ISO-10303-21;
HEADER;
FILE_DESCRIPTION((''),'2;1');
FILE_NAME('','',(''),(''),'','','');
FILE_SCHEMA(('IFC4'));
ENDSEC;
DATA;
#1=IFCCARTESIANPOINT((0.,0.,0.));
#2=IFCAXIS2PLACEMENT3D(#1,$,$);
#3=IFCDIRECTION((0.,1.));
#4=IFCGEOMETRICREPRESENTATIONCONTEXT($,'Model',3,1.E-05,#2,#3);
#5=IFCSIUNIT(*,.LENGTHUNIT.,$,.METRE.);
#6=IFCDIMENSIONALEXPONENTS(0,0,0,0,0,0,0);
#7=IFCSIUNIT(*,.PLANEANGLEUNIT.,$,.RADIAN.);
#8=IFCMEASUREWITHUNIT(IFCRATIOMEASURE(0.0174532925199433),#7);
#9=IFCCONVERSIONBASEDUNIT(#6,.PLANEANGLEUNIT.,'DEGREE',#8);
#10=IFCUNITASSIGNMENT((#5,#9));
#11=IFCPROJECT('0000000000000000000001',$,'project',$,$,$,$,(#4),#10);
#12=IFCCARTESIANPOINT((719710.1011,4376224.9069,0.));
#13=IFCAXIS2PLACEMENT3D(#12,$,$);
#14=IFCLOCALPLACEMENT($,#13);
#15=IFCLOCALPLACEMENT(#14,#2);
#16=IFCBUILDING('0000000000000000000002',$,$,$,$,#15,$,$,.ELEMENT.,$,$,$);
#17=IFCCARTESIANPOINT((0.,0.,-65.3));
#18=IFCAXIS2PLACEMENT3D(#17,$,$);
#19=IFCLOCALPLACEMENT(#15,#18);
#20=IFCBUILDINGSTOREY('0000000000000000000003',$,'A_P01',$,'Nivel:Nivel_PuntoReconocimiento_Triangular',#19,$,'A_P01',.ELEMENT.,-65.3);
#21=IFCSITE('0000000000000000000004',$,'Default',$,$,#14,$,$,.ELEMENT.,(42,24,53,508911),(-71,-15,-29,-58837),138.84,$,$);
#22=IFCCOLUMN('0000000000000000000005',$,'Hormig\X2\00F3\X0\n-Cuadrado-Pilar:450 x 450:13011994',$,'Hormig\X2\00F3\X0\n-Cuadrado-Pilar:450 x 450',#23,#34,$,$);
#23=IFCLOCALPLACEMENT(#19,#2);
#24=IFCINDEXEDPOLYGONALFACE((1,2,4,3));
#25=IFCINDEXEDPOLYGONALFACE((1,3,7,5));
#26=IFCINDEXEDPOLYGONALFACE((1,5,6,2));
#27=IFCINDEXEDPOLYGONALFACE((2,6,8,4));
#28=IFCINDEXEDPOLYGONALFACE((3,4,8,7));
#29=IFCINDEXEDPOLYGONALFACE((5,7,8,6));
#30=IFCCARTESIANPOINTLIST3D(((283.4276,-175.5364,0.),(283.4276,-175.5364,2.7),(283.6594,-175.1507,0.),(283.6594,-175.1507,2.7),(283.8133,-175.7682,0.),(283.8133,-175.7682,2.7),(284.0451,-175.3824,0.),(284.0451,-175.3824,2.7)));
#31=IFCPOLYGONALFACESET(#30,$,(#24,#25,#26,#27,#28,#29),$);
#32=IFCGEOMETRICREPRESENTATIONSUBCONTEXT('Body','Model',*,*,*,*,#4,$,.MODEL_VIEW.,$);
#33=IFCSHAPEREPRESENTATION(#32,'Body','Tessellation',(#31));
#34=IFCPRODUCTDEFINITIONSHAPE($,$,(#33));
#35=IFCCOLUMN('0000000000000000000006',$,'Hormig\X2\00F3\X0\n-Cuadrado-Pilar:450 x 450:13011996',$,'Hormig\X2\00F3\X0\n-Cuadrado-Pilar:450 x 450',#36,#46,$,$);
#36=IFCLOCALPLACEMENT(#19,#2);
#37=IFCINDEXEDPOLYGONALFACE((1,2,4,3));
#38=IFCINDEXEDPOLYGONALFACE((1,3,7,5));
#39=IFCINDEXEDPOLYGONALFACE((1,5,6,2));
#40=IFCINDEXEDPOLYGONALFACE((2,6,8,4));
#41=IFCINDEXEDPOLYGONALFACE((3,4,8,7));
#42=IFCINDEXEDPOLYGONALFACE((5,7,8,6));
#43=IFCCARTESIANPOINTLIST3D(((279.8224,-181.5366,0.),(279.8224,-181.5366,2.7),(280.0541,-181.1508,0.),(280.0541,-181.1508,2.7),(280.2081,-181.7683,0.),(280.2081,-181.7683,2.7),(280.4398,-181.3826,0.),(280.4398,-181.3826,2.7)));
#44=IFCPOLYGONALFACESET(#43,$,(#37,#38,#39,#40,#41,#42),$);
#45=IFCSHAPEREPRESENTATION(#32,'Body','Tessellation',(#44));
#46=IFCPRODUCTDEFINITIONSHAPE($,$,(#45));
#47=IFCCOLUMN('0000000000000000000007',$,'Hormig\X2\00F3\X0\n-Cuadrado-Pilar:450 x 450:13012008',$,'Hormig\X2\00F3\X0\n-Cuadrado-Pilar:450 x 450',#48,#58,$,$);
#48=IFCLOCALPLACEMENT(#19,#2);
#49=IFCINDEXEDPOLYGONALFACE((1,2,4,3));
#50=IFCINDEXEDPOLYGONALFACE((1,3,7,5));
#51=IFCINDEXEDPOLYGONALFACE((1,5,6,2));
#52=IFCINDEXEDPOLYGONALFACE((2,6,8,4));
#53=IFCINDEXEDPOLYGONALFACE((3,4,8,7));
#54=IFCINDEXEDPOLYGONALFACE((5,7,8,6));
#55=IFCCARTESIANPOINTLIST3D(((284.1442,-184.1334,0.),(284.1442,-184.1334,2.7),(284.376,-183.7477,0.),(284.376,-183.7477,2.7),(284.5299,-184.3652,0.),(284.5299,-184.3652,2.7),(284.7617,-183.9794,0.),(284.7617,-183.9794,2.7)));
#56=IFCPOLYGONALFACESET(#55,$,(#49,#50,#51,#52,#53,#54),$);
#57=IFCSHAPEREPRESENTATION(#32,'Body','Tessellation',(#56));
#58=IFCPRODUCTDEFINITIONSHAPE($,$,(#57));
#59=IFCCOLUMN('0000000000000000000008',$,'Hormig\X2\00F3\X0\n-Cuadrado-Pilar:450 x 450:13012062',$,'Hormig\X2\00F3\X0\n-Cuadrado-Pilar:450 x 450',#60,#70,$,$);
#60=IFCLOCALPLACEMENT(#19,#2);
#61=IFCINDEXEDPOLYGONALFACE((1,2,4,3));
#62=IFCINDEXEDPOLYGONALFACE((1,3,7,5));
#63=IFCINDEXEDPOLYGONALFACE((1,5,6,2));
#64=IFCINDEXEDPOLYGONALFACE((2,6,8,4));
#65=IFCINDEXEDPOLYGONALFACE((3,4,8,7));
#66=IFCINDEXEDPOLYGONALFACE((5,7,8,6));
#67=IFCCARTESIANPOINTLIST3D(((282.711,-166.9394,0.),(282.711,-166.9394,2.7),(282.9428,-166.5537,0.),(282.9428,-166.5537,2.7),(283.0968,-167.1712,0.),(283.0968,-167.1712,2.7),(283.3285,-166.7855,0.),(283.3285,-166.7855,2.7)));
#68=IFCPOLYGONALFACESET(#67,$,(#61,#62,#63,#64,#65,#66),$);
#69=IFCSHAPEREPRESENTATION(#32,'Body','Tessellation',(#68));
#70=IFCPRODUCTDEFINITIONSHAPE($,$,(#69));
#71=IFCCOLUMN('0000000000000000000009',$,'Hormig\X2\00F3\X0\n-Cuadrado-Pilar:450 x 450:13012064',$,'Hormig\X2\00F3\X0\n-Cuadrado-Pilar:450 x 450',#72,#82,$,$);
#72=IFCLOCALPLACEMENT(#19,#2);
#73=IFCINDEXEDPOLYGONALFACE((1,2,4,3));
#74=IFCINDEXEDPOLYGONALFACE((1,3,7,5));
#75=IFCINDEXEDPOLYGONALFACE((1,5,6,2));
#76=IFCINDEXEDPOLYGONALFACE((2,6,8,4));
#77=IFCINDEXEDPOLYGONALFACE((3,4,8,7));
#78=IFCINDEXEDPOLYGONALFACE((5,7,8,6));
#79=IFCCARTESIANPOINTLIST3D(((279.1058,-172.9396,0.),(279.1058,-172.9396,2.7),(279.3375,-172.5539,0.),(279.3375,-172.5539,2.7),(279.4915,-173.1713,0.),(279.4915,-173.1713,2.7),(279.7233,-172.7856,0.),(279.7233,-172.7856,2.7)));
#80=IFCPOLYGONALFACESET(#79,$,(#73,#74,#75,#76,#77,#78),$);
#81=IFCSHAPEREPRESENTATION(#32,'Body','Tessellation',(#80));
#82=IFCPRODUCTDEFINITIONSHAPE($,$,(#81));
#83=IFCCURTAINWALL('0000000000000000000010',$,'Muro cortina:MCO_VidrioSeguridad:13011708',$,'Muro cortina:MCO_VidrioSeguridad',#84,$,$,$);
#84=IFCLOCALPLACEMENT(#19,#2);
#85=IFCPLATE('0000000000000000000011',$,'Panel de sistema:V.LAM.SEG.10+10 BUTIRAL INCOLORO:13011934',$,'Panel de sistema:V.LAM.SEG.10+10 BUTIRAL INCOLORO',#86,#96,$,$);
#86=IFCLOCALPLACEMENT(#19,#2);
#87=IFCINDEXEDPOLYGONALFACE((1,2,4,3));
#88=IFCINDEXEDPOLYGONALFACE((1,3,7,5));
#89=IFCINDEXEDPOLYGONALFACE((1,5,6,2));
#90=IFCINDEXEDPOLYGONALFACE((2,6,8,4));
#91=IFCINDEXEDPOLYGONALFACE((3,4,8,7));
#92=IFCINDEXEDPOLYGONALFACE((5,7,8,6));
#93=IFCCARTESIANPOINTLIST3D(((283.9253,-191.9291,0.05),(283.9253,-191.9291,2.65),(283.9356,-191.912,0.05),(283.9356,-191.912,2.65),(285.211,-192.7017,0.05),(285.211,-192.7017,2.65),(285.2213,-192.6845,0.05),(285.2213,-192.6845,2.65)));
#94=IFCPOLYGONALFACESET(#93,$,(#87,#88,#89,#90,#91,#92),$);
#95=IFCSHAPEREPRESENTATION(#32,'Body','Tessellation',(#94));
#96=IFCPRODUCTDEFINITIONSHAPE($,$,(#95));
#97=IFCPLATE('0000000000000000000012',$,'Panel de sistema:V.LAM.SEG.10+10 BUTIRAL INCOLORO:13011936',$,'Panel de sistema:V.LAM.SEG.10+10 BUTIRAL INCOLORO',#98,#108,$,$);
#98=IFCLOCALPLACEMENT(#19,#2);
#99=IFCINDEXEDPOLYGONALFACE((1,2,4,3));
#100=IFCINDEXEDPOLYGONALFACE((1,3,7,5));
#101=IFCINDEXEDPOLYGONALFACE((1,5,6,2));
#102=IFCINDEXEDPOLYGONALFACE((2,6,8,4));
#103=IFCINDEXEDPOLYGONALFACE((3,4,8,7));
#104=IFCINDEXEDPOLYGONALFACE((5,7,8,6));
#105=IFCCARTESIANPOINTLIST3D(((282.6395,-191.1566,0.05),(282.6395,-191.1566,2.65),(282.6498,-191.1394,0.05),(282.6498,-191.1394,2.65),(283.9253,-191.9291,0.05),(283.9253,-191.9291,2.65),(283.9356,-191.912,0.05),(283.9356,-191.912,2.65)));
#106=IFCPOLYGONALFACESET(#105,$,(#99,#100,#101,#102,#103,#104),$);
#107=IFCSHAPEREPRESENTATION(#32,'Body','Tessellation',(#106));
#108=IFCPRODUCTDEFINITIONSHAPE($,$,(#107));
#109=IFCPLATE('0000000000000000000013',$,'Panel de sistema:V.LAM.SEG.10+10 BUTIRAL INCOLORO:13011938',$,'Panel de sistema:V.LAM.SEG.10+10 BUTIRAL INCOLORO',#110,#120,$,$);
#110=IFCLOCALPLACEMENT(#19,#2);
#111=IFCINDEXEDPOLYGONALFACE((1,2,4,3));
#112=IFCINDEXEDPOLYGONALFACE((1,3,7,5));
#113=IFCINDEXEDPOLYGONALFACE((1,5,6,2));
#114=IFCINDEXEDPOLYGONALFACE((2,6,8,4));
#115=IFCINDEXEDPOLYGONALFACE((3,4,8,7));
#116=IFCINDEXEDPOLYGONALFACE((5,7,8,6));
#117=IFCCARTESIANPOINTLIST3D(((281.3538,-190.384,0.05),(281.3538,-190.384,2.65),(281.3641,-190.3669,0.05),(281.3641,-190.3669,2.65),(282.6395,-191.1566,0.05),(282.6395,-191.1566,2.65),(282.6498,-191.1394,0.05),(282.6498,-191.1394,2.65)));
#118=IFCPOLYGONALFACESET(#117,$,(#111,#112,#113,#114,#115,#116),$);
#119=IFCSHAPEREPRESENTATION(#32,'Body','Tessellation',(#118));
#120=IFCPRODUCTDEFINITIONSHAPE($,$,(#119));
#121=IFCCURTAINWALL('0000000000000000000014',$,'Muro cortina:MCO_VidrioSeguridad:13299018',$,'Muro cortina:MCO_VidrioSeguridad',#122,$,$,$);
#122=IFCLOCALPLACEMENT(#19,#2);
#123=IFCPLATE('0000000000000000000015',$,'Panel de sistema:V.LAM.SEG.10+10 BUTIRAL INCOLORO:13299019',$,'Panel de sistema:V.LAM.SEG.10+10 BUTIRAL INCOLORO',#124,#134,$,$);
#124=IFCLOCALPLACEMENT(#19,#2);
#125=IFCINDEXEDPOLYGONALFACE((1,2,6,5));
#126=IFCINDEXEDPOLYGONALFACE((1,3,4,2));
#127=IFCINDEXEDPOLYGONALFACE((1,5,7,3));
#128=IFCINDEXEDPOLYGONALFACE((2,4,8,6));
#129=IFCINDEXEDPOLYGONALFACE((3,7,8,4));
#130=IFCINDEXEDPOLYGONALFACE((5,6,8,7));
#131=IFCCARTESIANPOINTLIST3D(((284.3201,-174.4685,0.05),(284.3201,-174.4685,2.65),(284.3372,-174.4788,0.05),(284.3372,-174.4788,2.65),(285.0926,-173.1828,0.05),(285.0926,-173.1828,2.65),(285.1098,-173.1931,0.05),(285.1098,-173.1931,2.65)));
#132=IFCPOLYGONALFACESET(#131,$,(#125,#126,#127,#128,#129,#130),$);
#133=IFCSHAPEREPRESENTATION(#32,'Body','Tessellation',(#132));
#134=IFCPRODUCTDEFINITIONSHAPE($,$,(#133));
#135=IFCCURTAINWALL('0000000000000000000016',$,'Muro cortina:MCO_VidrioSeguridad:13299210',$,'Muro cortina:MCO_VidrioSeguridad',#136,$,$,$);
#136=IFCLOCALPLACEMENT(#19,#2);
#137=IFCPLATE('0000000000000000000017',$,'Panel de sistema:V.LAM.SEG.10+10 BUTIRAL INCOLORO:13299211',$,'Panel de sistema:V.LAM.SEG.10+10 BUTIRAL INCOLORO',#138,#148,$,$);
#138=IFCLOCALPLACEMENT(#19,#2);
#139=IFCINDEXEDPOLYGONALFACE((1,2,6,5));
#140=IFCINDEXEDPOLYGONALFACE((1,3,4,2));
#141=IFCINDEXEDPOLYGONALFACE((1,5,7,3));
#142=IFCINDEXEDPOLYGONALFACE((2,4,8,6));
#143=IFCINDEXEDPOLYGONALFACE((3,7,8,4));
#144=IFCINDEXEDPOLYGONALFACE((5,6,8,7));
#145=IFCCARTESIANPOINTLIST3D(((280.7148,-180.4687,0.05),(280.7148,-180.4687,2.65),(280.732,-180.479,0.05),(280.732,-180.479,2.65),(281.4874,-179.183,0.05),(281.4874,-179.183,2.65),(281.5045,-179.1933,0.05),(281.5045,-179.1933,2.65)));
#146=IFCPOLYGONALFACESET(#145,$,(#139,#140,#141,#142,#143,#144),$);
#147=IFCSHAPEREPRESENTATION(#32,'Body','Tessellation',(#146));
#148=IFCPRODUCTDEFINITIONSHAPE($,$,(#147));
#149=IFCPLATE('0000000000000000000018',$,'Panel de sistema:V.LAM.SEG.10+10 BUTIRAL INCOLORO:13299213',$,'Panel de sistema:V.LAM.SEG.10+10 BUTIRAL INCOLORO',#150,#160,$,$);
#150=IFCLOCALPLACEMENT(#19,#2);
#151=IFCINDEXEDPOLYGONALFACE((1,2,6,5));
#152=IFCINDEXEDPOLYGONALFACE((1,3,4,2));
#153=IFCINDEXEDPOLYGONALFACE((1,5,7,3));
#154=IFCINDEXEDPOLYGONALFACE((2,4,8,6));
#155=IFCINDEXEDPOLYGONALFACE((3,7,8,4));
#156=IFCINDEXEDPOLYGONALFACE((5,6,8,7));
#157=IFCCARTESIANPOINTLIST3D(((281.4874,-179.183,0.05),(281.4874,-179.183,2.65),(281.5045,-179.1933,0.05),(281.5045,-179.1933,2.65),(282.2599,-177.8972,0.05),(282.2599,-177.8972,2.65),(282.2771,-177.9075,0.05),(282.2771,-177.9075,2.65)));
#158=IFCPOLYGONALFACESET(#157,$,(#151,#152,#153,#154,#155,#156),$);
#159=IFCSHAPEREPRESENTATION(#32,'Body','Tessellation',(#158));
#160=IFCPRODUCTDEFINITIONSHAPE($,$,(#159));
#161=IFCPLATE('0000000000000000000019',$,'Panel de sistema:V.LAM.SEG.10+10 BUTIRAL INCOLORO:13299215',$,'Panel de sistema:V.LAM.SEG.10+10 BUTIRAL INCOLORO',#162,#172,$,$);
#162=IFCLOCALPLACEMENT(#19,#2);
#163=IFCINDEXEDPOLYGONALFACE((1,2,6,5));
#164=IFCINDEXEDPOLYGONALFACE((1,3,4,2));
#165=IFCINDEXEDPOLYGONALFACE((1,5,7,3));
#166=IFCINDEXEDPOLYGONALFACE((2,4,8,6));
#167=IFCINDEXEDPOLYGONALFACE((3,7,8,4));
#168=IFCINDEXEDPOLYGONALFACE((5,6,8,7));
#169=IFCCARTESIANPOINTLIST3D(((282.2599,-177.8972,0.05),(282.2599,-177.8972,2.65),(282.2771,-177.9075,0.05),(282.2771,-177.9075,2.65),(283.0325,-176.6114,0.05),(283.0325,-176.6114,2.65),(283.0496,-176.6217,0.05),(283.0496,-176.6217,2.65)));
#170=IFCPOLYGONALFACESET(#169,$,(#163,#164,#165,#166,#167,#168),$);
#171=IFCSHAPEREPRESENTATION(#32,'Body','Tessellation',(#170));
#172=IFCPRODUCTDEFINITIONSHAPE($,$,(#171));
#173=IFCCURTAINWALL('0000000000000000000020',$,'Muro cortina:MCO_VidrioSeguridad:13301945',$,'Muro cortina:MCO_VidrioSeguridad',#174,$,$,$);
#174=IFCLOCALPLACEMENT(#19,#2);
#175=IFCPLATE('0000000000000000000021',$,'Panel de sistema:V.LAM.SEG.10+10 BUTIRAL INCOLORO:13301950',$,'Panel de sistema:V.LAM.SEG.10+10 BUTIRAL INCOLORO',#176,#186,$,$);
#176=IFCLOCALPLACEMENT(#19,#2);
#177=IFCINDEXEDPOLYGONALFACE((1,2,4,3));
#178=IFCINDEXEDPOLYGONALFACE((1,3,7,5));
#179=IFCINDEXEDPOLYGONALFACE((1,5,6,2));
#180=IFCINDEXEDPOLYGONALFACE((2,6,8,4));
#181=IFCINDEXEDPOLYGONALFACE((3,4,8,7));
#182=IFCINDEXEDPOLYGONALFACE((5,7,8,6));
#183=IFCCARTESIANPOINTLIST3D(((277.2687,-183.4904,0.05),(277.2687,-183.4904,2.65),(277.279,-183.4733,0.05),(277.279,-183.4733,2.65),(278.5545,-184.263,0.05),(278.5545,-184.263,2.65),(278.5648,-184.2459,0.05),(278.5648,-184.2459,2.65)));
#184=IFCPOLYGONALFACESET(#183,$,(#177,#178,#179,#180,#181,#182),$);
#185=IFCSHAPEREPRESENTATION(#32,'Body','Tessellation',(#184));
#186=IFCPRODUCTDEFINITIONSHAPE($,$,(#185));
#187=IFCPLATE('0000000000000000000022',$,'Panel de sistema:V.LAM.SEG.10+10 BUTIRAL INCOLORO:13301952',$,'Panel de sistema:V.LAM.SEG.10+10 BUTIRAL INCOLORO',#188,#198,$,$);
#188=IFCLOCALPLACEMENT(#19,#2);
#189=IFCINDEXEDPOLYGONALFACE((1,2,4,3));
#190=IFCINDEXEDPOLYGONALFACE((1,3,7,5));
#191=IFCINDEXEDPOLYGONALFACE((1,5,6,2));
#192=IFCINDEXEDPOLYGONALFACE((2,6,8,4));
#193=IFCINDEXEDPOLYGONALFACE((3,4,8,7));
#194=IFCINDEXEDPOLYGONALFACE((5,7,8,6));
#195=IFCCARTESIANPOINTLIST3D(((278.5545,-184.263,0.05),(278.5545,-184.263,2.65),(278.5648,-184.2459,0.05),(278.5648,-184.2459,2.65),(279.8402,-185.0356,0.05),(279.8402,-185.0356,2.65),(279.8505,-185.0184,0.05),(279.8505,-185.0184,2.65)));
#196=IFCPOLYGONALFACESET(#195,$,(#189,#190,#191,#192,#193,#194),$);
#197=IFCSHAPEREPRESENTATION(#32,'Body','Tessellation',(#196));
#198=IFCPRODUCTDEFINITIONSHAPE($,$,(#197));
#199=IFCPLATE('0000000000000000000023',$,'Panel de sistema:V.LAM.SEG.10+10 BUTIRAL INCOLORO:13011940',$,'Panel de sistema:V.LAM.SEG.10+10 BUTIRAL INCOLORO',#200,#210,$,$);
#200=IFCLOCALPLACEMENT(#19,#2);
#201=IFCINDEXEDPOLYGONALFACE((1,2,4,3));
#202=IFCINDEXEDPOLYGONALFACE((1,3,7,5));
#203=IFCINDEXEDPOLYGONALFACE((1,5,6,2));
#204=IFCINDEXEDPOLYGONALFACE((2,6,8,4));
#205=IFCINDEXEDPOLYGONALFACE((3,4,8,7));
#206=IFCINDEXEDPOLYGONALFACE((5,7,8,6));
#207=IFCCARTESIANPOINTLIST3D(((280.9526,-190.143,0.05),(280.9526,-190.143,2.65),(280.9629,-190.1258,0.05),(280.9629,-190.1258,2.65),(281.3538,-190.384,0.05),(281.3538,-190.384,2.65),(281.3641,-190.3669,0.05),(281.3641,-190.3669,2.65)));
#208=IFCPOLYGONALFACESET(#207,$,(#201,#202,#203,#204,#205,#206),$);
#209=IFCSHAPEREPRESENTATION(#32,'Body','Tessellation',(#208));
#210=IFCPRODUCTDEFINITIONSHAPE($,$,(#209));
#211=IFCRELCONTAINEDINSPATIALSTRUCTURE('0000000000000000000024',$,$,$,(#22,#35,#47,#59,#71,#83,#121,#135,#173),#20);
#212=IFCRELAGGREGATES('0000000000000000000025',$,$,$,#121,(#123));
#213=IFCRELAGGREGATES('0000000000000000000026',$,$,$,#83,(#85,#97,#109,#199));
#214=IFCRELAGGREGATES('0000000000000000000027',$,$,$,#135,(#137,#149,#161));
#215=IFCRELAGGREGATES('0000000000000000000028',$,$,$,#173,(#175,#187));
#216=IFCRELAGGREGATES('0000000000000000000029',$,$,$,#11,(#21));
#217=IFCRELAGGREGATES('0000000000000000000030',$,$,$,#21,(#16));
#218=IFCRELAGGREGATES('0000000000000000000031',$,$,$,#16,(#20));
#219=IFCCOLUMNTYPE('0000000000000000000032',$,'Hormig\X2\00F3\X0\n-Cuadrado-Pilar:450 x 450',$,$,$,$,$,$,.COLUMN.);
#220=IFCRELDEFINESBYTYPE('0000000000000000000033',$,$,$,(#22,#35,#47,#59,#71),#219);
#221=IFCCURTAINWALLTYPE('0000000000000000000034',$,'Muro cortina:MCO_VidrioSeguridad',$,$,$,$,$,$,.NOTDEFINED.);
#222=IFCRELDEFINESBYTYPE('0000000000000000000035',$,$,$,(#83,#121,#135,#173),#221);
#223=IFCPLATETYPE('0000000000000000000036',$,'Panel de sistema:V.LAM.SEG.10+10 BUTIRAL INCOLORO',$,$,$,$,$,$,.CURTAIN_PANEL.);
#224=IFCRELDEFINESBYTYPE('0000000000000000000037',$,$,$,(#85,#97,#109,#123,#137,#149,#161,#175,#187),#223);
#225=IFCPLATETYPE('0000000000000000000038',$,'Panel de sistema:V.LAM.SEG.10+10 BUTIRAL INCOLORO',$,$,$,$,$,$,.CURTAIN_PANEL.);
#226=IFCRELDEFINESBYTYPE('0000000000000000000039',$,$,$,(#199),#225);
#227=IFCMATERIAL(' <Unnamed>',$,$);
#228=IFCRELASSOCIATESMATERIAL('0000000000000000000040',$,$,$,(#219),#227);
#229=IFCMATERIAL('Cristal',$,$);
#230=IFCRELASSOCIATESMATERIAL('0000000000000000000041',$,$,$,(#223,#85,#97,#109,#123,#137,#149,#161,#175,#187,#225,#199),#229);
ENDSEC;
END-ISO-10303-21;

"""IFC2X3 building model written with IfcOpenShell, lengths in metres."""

from ifc_helpers import new_model, entity, si_unit, converted_unit, direction, frame, origin, origin_2d_with_axis, place, context, subcontext, project, spatial, rectangle, extrude, source, transform, mapped, material, type_object, type_shapes, element, aggregate, save


model = new_model("IFC2X3")

# Units and contexts
model_context = context("Model", 3, precision=1e-05, world=origin(), true_north=direction((0.0, 1.0)))
body_context = subcontext(model_context, "Body", "Model", "MODEL_VIEW")
ifc_project = project(units=[si_unit("LENGTHUNIT", "METRE"), converted_unit("PLANEANGLEUNIT", "DEGREE", entity("IfcRatioMeasure", 0.0174532925199433), si_unit("PLANEANGLEUNIT", "RADIAN"), dimensions=[0, 0, 0, 0, 0, 0, 0])], contexts=[model_context])

# Site, building, storey
site_placement = place(None, frame((719710.1011, 4376224.9069, 0.0)))
site = spatial("IfcSite", under=ifc_project, at=site_placement, Name="Default", CompositionType="ELEMENT", RefLatitude=(42, 24, 53, 508911), RefLongitude=(-71, -15, -29, -58837), RefElevation=138.84)
building_placement = place(site_placement, origin())
building = spatial("IfcBuilding", under=site, at=building_placement, CompositionType="ELEMENT")
storey_placement = place(building_placement, frame((0.0, 0.0, -65.3)))
storey = spatial("IfcBuildingStorey", under=building, at=storey_placement, Name="A_P01", ObjectType="Nivel:Nivel_PuntoReconocimiento_Triangular", LongName="A_P01", CompositionType="ELEMENT", Elevation=-65.3)

# Columns
ifc_material_1 = material(Name=" <Unnamed>")
column_type = type_object("IfcColumnType", Name="Hormigón-Cuadrado-Pilar:450 x 450", PredefinedType="COLUMN", material=ifc_material_1)
shared_shape_1 = source(origin(), body_context, "Body", "SweptSolid", [
    extrude(rectangle(XDim=0.45, YDim=0.45, at=origin_2d_with_axis()), frame((0.0, 0.0, -65.3), z_axis=(0.0, 0.0, 1.0), x_axis=(0.0, -1.0, 0.0)), (0.0, 0.0, 1.0), 2.7),
])
type_shapes(column_type, [shared_shape_1])
for number, where, z_axis, x_axis, name in (
    (1, (283.7364, -175.4594, 65.3), (0.0, 0.0, 1.0), (0.857167, -0.515038, 0.0), "Hormigón-Cuadrado-Pilar:450 x 450:13011994"),
    (2, (280.1311, -181.4596, 65.3), (0.0, 0.0, 1.0), (0.857167, -0.515038, 0.0), "Hormigón-Cuadrado-Pilar:450 x 450:13011996"),
    (3, (284.4529, -184.0564, 65.3), (0.0, 0.0, 1.0), (0.857167, -0.515038, 0.0), "Hormigón-Cuadrado-Pilar:450 x 450:13012008"),
    (4, (283.0198, -166.8624, 65.3), (0.0, 0.0, 1.0), (0.857167, -0.515038, 0.0), "Hormigón-Cuadrado-Pilar:450 x 450:13012062"),
    (5, (279.4145, -172.8626, 65.3), (0.0, 0.0, 1.0), (0.857167, -0.515038, 0.0), "Hormigón-Cuadrado-Pilar:450 x 450:13012064"),
):
    element("IfcColumn", number, at=place(storey_placement, frame(where, z_axis=z_axis, x_axis=x_axis)), inside=storey, type_object=column_type, Name=name, ObjectType="Hormigón-Cuadrado-Pilar:450 x 450", context=body_context, shape_type="MappedRepresentation", body=[
        mapped(shared_shape_1, transform((0.0, 0.0, 0.0), scale=1.0)),
    ])

# Curtain wall, plates
curtain_wall_type = type_object("IfcCurtainWallType", Name="Muro cortina:MCO_VidrioSeguridad", PredefinedType="NOTDEFINED")
curtain_wall_1_placement = place(storey_placement, frame((0.0, 0.0, 65.3)))
curtain_wall_1 = element("IfcCurtainWall", 6, at=curtain_wall_1_placement, inside=storey, type_object=curtain_wall_type, Name="Muro cortina:MCO_VidrioSeguridad:13011708", ObjectType="Muro cortina:MCO_VidrioSeguridad")
ifc_material_2 = material(Name="Cristal")
plate_type_1 = type_object("IfcPlateType", Name="Panel de sistema:V.LAM.SEG.10+10 BUTIRAL INCOLORO", PredefinedType="CURTAIN_PANEL", material=ifc_material_2)
shared_shape_2 = source(origin(), body_context, "Body", "SweptSolid", [
    extrude(rectangle(XDim=0.02, YDim=1.5, at=origin_2d_with_axis()), frame((0.0, 0.0, 0.0), z_axis=(0.0, 0.0, 1.0), x_axis=(0.0, 1.0, 0.0)), (0.0, 0.0, 1.0), 2.6),
])
type_shapes(plate_type_1, [shared_shape_2])
plate_1_placement = place(curtain_wall_1_placement, frame((284.5733, -192.3068, -65.25), z_axis=(0.0, 0.0, 1.0), x_axis=(-0.857167, 0.515038, 0.0)))
plate_1 = element("IfcPlate", 7, at=plate_1_placement, type_object=plate_type_1, material=ifc_material_2, Name="Panel de sistema:V.LAM.SEG.10+10 BUTIRAL INCOLORO:13011934", ObjectType="Panel de sistema:V.LAM.SEG.10+10 BUTIRAL INCOLORO", context=body_context, shape_type="MappedRepresentation", body=[
    mapped(shared_shape_2, transform((0.0, 0.0, 0.0), scale=1.0)),
])
plate_2_placement = place(curtain_wall_1_placement, frame((283.2875, -191.5343, -65.25), z_axis=(0.0, 0.0, 1.0), x_axis=(-0.857167, 0.515038, 0.0)))
plate_2 = element("IfcPlate", 8, at=plate_2_placement, type_object=plate_type_1, material=ifc_material_2, Name="Panel de sistema:V.LAM.SEG.10+10 BUTIRAL INCOLORO:13011936", ObjectType="Panel de sistema:V.LAM.SEG.10+10 BUTIRAL INCOLORO", context=body_context, shape_type="MappedRepresentation", body=[
    mapped(shared_shape_2, transform((0.0, 0.0, 0.0), scale=1.0)),
])
plate_3_placement = place(curtain_wall_1_placement, frame((282.0018, -190.7617, -65.25), z_axis=(0.0, 0.0, 1.0), x_axis=(-0.857167, 0.515038, 0.0)))
plate_3 = element("IfcPlate", 9, at=plate_3_placement, type_object=plate_type_1, material=ifc_material_2, Name="Panel de sistema:V.LAM.SEG.10+10 BUTIRAL INCOLORO:13011938", ObjectType="Panel de sistema:V.LAM.SEG.10+10 BUTIRAL INCOLORO", context=body_context, shape_type="MappedRepresentation", body=[
    mapped(shared_shape_2, transform((0.0, 0.0, 0.0), scale=1.0)),
])

# Curtain wall, plate
curtain_wall_2_placement = place(storey_placement, frame((0.0, 0.0, 65.3)))
curtain_wall_2 = element("IfcCurtainWall", 10, at=curtain_wall_2_placement, inside=storey, type_object=curtain_wall_type, Name="Muro cortina:MCO_VidrioSeguridad:13299018", ObjectType="Muro cortina:MCO_VidrioSeguridad")
plate_4_placement = place(curtain_wall_2_placement, frame((284.7149, -173.8308, -65.25), z_axis=(0.0, 0.0, 1.0), x_axis=(0.515038, 0.857167, 0.0)))
plate_4 = element("IfcPlate", 11, at=plate_4_placement, type_object=plate_type_1, material=ifc_material_2, Name="Panel de sistema:V.LAM.SEG.10+10 BUTIRAL INCOLORO:13299019", ObjectType="Panel de sistema:V.LAM.SEG.10+10 BUTIRAL INCOLORO", context=body_context, shape_type="MappedRepresentation", body=[
    mapped(shared_shape_2, transform((0.0, 0.0, 0.0), scale=1.0)),
])
aggregate(curtain_wall_2, [plate_4])

# Curtain walls, plates
curtain_wall_3_placement = place(storey_placement, frame((0.0, 0.0, 65.3)))
curtain_wall_3 = element("IfcCurtainWall", 12, at=curtain_wall_3_placement, inside=storey, type_object=curtain_wall_type, Name="Muro cortina:MCO_VidrioSeguridad:13299210", ObjectType="Muro cortina:MCO_VidrioSeguridad")
plate_5_placement = place(curtain_wall_3_placement, frame((281.1097, -179.831, -65.25), z_axis=(0.0, 0.0, 1.0), x_axis=(0.515038, 0.857167, 0.0)))
plate_5 = element("IfcPlate", 13, at=plate_5_placement, type_object=plate_type_1, material=ifc_material_2, Name="Panel de sistema:V.LAM.SEG.10+10 BUTIRAL INCOLORO:13299211", ObjectType="Panel de sistema:V.LAM.SEG.10+10 BUTIRAL INCOLORO", context=body_context, shape_type="MappedRepresentation", body=[
    mapped(shared_shape_2, transform((0.0, 0.0, 0.0), scale=1.0)),
])
plate_6_placement = place(curtain_wall_3_placement, frame((281.8822, -178.5452, -65.25), z_axis=(0.0, 0.0, 1.0), x_axis=(0.515038, 0.857167, 0.0)))
plate_6 = element("IfcPlate", 14, at=plate_6_placement, type_object=plate_type_1, material=ifc_material_2, Name="Panel de sistema:V.LAM.SEG.10+10 BUTIRAL INCOLORO:13299213", ObjectType="Panel de sistema:V.LAM.SEG.10+10 BUTIRAL INCOLORO", context=body_context, shape_type="MappedRepresentation", body=[
    mapped(shared_shape_2, transform((0.0, 0.0, 0.0), scale=1.0)),
])
plate_7_placement = place(curtain_wall_3_placement, frame((282.6548, -177.2595, -65.25), z_axis=(0.0, 0.0, 1.0), x_axis=(0.515038, 0.857167, 0.0)))
plate_7 = element("IfcPlate", 15, at=plate_7_placement, type_object=plate_type_1, material=ifc_material_2, Name="Panel de sistema:V.LAM.SEG.10+10 BUTIRAL INCOLORO:13299215", ObjectType="Panel de sistema:V.LAM.SEG.10+10 BUTIRAL INCOLORO", context=body_context, shape_type="MappedRepresentation", body=[
    mapped(shared_shape_2, transform((0.0, 0.0, 0.0), scale=1.0)),
])
curtain_wall_4_placement = place(storey_placement, frame((0.0, 0.0, 65.3)))
curtain_wall_4 = element("IfcCurtainWall", 16, at=curtain_wall_4_placement, inside=storey, type_object=curtain_wall_type, Name="Muro cortina:MCO_VidrioSeguridad:13301945", ObjectType="Muro cortina:MCO_VidrioSeguridad")
plate_8_placement = place(curtain_wall_4_placement, frame((277.9168, -183.8681, -65.25), z_axis=(0.0, 0.0, 1.0), x_axis=(0.857167, -0.515038, 0.0)))
plate_8 = element("IfcPlate", 17, at=plate_8_placement, type_object=plate_type_1, material=ifc_material_2, Name="Panel de sistema:V.LAM.SEG.10+10 BUTIRAL INCOLORO:13301950", ObjectType="Panel de sistema:V.LAM.SEG.10+10 BUTIRAL INCOLORO", context=body_context, shape_type="MappedRepresentation", body=[
    mapped(shared_shape_2, transform((0.0, 0.0, 0.0), scale=1.0)),
])
plate_9_placement = place(curtain_wall_4_placement, frame((279.2025, -184.6407, -65.25), z_axis=(0.0, 0.0, 1.0), x_axis=(0.857167, -0.515038, 0.0)))
plate_9 = element("IfcPlate", 18, at=plate_9_placement, type_object=plate_type_1, material=ifc_material_2, Name="Panel de sistema:V.LAM.SEG.10+10 BUTIRAL INCOLORO:13301952", ObjectType="Panel de sistema:V.LAM.SEG.10+10 BUTIRAL INCOLORO", context=body_context, shape_type="MappedRepresentation", body=[
    mapped(shared_shape_2, transform((0.0, 0.0, 0.0), scale=1.0)),
])

# Plate
plate_type_2 = type_object("IfcPlateType", Name="Panel de sistema:V.LAM.SEG.10+10 BUTIRAL INCOLORO", PredefinedType="CURTAIN_PANEL", material=ifc_material_2)
shared_shape_3 = source(origin(), body_context, "Body", "SweptSolid", [
    extrude(rectangle(XDim=0.02, YDim=0.468, at=origin_2d_with_axis()), frame((0.0, 0.0, 0.0), z_axis=(0.0, 0.0, 1.0), x_axis=(0.0, 1.0, 0.0)), (0.0, 0.0, 1.0), 2.6),
])
type_shapes(plate_type_2, [shared_shape_3])
plate_10_placement = place(curtain_wall_1_placement, frame((281.1583, -190.2549, -65.25), z_axis=(0.0, 0.0, 1.0), x_axis=(-0.857167, 0.515038, 0.0)))
plate_10 = element("IfcPlate", 19, at=plate_10_placement, type_object=plate_type_2, material=ifc_material_2, Name="Panel de sistema:V.LAM.SEG.10+10 BUTIRAL INCOLORO:13011940", ObjectType="Panel de sistema:V.LAM.SEG.10+10 BUTIRAL INCOLORO", context=body_context, shape_type="MappedRepresentation", body=[
    mapped(shared_shape_3, transform((0.0, 0.0, 0.0), scale=1.0)),
])
aggregate(curtain_wall_1, [plate_1, plate_2, plate_3, plate_10])
aggregate(curtain_wall_3, [plate_5, plate_6, plate_7])
aggregate(curtain_wall_4, [plate_8, plate_9])

save(model, "model.ifc")
